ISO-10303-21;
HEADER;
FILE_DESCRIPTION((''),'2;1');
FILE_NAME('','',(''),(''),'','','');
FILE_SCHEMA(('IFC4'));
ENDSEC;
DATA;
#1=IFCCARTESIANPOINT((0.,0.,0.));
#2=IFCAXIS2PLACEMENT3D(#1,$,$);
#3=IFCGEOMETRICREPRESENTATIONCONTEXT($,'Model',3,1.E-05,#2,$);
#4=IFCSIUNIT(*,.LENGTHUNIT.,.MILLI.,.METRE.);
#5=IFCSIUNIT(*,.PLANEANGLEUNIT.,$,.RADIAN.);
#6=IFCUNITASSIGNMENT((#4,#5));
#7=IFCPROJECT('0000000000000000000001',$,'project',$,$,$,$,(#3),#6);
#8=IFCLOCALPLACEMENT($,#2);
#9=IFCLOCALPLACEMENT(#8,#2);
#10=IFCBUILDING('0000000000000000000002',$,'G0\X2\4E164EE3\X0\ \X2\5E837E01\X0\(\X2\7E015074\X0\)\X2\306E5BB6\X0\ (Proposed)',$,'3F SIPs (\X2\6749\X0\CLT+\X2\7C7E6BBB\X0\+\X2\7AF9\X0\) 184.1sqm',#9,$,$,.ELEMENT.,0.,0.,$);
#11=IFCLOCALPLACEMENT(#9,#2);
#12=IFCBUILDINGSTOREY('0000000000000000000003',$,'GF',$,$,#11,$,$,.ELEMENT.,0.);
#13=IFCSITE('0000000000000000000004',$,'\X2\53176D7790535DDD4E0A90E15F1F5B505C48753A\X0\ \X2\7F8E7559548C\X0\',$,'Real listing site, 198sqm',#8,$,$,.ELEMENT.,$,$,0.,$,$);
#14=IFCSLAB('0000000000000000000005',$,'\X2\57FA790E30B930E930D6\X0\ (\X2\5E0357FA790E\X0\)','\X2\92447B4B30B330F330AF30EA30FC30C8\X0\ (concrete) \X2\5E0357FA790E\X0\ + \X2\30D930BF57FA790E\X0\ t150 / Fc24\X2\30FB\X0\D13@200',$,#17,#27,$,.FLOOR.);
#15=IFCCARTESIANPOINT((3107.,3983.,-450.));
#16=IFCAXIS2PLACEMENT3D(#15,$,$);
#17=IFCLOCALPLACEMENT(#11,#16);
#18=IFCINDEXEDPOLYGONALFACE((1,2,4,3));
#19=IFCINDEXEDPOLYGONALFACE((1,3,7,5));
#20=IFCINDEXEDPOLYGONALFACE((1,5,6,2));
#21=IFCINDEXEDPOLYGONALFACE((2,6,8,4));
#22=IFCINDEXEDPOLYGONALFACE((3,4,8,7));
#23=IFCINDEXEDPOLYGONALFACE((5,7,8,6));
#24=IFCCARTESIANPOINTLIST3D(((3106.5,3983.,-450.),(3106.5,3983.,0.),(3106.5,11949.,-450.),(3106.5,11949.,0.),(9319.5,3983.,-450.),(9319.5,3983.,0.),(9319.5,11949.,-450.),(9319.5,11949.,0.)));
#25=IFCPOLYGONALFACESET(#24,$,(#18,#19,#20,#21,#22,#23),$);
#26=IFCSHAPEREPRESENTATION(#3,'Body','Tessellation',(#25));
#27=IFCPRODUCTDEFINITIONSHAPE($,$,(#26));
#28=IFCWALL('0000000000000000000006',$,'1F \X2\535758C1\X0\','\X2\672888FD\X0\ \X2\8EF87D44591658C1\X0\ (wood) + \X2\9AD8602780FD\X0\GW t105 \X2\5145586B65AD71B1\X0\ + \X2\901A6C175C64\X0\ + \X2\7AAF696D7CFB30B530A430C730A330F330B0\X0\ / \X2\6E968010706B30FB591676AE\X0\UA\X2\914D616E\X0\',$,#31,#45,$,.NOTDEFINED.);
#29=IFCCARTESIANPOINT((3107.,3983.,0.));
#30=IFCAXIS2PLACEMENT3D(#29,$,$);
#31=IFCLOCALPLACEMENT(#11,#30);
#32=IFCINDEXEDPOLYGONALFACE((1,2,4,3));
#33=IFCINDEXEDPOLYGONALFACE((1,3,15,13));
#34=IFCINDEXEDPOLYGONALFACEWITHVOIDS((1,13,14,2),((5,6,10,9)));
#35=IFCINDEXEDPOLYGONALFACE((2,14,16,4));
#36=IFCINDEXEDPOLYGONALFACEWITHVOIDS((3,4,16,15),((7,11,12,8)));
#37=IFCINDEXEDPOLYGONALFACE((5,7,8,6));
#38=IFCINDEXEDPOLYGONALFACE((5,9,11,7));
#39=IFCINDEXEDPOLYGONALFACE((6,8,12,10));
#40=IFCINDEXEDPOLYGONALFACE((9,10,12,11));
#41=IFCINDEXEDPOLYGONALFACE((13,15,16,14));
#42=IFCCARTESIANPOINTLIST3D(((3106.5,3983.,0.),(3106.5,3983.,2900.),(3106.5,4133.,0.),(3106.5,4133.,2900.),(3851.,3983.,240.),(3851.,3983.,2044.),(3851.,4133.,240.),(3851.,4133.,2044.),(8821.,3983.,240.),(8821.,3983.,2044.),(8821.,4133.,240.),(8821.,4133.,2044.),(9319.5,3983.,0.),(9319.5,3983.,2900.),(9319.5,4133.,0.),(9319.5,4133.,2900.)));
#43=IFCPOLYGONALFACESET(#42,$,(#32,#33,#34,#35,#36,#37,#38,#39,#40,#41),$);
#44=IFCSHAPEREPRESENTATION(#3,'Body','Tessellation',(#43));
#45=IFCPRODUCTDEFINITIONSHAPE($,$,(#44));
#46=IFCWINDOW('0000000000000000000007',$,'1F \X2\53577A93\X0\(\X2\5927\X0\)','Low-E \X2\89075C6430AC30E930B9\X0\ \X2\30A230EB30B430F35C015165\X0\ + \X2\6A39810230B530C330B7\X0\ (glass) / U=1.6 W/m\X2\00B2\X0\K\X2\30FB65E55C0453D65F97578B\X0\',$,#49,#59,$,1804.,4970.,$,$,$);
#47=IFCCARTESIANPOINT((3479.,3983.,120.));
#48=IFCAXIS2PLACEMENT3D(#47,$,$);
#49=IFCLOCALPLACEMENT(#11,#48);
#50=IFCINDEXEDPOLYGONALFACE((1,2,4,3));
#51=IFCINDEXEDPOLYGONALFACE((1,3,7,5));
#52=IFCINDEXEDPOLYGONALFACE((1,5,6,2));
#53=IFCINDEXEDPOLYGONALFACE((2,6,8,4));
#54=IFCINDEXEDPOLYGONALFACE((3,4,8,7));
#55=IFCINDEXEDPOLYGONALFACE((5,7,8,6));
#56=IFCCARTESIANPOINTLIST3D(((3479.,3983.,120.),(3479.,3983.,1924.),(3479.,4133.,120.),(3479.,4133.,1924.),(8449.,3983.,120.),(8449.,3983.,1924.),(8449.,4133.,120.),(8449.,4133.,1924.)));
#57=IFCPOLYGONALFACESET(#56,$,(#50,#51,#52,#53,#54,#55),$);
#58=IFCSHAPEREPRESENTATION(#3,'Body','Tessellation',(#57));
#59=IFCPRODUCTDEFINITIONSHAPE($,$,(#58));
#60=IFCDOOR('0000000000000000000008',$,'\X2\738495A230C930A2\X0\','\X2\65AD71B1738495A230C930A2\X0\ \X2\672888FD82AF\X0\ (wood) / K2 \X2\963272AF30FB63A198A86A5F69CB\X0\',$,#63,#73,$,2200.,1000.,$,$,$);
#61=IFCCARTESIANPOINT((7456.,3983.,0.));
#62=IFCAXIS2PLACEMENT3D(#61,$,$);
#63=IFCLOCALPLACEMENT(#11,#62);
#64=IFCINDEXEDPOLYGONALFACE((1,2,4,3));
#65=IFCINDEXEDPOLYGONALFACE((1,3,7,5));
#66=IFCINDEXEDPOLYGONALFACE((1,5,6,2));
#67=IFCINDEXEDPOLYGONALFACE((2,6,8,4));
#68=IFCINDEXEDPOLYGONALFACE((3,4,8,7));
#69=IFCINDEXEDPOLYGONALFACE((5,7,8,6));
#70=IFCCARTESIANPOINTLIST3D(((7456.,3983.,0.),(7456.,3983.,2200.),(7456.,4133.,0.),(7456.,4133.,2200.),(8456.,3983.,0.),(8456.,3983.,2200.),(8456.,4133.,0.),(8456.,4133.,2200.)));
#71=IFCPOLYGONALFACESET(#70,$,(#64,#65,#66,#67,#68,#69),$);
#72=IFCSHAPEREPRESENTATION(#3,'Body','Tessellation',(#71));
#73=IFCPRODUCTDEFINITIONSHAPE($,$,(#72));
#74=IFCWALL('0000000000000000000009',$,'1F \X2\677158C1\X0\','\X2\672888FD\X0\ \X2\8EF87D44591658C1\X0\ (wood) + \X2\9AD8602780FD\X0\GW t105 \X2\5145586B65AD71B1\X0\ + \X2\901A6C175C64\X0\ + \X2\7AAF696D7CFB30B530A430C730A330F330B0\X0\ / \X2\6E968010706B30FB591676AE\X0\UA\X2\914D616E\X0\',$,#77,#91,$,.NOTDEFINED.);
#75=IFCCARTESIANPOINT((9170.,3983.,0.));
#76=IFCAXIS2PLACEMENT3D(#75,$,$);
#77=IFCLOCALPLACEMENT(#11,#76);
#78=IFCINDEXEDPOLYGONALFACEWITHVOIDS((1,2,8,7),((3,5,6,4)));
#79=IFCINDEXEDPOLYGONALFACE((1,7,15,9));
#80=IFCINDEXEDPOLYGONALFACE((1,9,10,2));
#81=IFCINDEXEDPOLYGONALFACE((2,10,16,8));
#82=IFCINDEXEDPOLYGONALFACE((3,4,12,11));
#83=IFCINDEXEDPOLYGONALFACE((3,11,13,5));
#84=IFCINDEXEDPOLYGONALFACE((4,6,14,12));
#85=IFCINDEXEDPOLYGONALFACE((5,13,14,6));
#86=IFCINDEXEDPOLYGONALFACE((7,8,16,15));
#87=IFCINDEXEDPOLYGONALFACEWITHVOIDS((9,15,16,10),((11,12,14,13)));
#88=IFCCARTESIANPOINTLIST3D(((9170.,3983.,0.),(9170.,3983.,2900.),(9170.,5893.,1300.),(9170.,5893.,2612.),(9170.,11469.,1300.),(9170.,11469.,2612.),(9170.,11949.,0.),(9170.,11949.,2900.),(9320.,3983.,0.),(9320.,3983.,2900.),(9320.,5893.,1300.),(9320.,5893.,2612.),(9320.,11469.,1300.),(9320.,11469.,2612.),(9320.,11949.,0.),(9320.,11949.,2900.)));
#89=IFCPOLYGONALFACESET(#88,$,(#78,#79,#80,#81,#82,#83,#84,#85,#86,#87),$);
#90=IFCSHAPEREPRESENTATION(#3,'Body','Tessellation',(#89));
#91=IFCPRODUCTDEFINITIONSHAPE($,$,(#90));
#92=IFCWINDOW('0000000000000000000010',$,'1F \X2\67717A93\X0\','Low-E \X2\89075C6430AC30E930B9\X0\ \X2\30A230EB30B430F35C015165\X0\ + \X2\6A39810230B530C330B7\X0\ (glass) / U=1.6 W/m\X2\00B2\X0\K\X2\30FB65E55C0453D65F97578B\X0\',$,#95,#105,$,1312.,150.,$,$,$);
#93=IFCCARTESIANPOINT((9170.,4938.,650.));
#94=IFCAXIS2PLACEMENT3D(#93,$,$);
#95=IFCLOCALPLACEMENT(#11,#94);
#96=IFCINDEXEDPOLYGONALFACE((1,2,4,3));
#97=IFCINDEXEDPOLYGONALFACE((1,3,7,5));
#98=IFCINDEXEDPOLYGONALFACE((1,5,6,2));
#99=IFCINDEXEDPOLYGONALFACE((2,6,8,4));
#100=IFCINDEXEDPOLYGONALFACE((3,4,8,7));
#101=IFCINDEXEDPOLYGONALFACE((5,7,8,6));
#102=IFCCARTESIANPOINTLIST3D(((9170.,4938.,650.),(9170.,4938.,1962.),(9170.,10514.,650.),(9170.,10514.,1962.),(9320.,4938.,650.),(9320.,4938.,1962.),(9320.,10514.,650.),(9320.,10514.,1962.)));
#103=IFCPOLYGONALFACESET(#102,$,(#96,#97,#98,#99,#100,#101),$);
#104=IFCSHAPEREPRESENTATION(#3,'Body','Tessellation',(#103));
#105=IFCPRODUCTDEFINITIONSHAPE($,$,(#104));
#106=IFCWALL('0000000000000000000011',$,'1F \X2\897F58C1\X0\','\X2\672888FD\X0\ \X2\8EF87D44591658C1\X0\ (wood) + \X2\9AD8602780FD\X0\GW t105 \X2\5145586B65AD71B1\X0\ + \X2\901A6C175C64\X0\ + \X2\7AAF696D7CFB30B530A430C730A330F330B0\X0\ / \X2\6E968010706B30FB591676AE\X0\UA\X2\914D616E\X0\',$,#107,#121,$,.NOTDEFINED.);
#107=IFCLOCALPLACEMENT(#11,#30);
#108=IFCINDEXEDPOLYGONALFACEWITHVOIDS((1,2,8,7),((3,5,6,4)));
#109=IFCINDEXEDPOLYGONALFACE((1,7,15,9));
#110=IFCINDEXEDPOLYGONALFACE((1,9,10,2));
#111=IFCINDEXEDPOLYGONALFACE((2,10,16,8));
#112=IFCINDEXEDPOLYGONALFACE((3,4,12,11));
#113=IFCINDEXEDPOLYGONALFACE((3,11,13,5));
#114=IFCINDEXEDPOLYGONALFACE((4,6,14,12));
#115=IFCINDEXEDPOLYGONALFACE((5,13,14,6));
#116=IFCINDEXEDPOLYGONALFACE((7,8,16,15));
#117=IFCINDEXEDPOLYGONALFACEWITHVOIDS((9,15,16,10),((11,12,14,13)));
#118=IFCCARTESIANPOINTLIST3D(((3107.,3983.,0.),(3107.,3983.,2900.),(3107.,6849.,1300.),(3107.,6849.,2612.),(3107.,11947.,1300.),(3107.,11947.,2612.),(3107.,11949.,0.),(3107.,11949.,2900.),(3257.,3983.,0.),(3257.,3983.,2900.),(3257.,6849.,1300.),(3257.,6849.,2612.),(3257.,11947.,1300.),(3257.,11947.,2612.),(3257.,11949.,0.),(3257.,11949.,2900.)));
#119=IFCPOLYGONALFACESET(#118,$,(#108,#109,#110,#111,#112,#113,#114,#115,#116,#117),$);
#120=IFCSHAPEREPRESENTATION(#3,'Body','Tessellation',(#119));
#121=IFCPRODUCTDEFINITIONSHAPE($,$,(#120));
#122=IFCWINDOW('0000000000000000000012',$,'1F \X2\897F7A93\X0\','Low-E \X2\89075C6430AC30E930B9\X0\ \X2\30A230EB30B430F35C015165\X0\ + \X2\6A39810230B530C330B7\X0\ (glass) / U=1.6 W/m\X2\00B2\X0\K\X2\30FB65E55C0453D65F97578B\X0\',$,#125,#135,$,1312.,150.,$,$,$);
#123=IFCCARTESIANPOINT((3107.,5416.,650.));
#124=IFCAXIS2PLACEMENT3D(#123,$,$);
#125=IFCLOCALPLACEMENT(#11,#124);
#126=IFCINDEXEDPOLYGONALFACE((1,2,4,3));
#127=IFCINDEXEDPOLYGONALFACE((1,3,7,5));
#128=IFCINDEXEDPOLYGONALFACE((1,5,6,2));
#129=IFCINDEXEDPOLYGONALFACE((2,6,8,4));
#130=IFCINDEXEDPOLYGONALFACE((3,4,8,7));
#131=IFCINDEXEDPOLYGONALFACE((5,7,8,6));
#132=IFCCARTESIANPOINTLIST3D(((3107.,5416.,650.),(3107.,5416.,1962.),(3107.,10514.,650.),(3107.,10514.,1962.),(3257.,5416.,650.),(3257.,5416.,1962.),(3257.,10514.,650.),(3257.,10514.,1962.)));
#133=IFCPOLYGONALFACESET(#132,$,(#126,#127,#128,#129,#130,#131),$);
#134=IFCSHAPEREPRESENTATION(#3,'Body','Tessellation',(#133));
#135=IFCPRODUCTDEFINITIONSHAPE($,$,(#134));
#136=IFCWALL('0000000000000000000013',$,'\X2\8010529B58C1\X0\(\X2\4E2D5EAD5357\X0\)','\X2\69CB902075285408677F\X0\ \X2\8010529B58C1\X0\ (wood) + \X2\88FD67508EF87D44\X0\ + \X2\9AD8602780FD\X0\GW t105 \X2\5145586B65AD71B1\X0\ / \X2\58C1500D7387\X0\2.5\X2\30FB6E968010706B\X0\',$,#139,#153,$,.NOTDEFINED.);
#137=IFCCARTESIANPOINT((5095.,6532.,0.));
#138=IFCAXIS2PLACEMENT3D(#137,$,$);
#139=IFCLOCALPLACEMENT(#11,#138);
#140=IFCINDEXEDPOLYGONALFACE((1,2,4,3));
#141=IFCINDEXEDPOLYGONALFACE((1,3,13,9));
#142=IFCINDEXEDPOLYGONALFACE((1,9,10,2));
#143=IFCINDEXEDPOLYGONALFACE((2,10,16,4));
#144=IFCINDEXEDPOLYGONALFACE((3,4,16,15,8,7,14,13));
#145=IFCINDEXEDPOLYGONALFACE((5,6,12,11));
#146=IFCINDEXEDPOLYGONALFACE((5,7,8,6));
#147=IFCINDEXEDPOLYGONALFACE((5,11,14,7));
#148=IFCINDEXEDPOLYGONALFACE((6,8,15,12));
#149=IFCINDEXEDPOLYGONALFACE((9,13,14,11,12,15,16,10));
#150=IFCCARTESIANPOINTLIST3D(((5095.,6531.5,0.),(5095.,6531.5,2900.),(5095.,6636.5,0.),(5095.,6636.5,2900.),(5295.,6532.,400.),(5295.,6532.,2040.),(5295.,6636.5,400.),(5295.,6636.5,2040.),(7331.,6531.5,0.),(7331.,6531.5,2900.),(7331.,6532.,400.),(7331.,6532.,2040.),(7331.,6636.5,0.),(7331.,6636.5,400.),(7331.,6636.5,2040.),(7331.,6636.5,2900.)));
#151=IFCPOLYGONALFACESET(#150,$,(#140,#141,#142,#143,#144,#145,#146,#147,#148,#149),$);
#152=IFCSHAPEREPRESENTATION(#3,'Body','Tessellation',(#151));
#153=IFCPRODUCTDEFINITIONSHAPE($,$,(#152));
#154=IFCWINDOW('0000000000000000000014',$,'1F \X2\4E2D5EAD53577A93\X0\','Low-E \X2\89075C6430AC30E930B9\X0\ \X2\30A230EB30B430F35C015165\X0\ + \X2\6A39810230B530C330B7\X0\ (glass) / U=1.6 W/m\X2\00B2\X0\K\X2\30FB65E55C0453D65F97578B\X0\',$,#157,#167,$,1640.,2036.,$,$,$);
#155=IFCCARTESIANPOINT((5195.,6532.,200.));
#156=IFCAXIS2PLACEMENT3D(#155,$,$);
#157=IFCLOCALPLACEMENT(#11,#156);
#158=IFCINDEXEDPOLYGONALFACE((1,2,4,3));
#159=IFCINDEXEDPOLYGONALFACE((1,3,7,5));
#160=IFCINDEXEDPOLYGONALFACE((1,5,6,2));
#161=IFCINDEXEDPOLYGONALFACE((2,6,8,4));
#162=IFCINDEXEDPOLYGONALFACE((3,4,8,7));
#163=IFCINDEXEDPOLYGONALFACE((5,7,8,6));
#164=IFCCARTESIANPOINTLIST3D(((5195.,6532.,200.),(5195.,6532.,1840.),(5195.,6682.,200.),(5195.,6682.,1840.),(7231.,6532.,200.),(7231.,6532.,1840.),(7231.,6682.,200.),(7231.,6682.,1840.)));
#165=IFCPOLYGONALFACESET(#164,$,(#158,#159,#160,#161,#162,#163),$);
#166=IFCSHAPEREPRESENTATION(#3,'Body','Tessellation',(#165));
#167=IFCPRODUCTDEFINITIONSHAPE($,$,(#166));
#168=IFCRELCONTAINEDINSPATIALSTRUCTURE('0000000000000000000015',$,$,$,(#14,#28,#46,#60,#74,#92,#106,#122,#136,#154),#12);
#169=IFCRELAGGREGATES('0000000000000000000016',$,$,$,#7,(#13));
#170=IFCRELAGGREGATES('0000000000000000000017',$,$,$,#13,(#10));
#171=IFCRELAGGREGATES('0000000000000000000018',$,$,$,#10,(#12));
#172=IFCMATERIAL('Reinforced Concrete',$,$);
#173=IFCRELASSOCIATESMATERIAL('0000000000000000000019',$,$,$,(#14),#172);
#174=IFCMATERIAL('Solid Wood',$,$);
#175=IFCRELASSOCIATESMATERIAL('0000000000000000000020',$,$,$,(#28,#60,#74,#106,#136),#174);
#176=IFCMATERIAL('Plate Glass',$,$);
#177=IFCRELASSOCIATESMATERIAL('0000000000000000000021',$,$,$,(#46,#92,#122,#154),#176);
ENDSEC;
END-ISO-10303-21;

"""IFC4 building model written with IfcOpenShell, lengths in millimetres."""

from ifc_helpers import new_model, si_unit, frame, frame_2d, origin, place, context, project, spatial, rectangle, extrude, material, element, fill, save


model = new_model("IFC4")

# Units and contexts
model_context = context("Model", 3, precision=1e-05, world=origin())
ifc_project = project(units=[si_unit("LENGTHUNIT", "METRE", prefix="MILLI"), si_unit("PLANEANGLEUNIT", "RADIAN")], contexts=[model_context])

# Site, building, storey
site_placement = place(None, origin())
site = spatial("IfcSite", under=ifc_project, at=site_placement, Name="北海道川上郡弟子屈町 美留和", ObjectType="Real listing site, 198sqm", CompositionType="ELEMENT", RefElevation=0.0)
building_placement = place(site_placement, origin())
building = spatial("IfcBuilding", under=site, at=building_placement, Name="G0世代 広縁(縁側)の家 (Proposed)", ObjectType="3F SIPs (杉CLT+籾殻+竹) 184.1sqm", CompositionType="ELEMENT", ElevationOfRefHeight=0.0, ElevationOfTerrain=0.0)
storey_placement = place(building_placement, origin())
storey = spatial("IfcBuildingStorey", under=building, at=storey_placement, Name="GF", CompositionType="ELEMENT", Elevation=0.0)

# Slab
ifc_material_1 = material(Name="Reinforced Concrete")
slab_1_placement = place(storey_placement, frame((3107.0, 3983.0, -450.0)))
element("IfcSlab", 1, at=slab_1_placement, inside=storey, material=ifc_material_1, Name="基礎スラブ (布基礎)", Description="鉄筋コンクリート (concrete) 布基礎 + ベタ基礎 t150 / Fc24・D13@200", PredefinedType="FLOOR", context=model_context, shape_type="SweptSolid", body=[
    extrude(rectangle(XDim=6213.0, YDim=7966.0, at=frame_2d((3106.0, 3983.0))), frame((3107.0, 3983.0, -450.0)), (0.0, 0.0, 1.0), 450.0),
])
ifc_material_2 = material(Name="Solid Wood")

# Wall, openings, window, door
wall_1_placement = place(storey_placement, frame((3107.0, 3983.0, 0.0)))
wall_1 = element("IfcWall", 2, at=wall_1_placement, inside=storey, material=ifc_material_2, Name="1F 南壁", Description="木製 軸組外壁 (wood) + 高性能GW t105 充填断熱 + 通気層 + 窯業系サイディング / 準耐火・外皮UA配慮", PredefinedType="NOTDEFINED", context=model_context, shape_type="SweptSolid", body=[
    extrude(rectangle(XDim=6213.0, YDim=150.0, at=frame_2d((3106.0, 75.0))), frame((3107.0, 3983.0, 0.0)), (0.0, 0.0, 1.0), 2900.0),
])
opening_1_placement = place(storey_placement, frame((3479.0, 3983.0, 120.0)))
opening_1 = element("IfcOpeningElement", 3, at=opening_1_placement, cuts=wall_1, PredefinedType="NOTDEFINED", context=model_context, shape_type="SweptSolid", body=[
    extrude(rectangle(XDim=4970.0, YDim=150.0, at=frame_2d((2485.0, 75.0))), frame((3479.0, 3983.0, 120.0)), (0.0, 0.0, 1.0), 1804.0),
])
opening_2_placement = place(storey_placement, frame((7456.0, 3983.0, 0.0)))
opening_2 = element("IfcOpeningElement", 4, at=opening_2_placement, cuts=wall_1, PredefinedType="NOTDEFINED", context=model_context, shape_type="SweptSolid", body=[
    extrude(rectangle(XDim=1000.0, YDim=150.0, at=frame_2d((500.0, 75.0))), frame((7456.0, 3983.0, 0.0)), (0.0, 0.0, 1.0), 2200.0),
])
ifc_material_3 = material(Name="Plate Glass")
window_1_placement = place(storey_placement, frame((3479.0, 3983.0, 120.0)))
window_1 = element("IfcWindow", 5, at=window_1_placement, inside=storey, material=ifc_material_3, Name="1F 南窓(大)", Description="Low-E 複層ガラス アルゴン封入 + 樹脂サッシ (glass) / U=1.6 W/m²K・日射取得型", OverallHeight=1804.0, OverallWidth=4970.0, context=model_context, shape_type="SweptSolid", body=[
    extrude(rectangle(XDim=4970.0, YDim=150.0, at=frame_2d((2485.0, 75.0))), frame((3479.0, 3983.0, 120.0)), (0.0, 0.0, 1.0), 1804.0),
])
fill(opening_1, window_1)
door_placement = place(storey_placement, frame((7456.0, 3983.0, 0.0)))
door = element("IfcDoor", 6, at=door_placement, inside=storey, material=ifc_material_2, Name="玄関ドア", Description="断熱玄関ドア 木製芯 (wood) / K2 防犯・採風機構", OverallHeight=2200.0, OverallWidth=1000.0, context=model_context, shape_type="SweptSolid", body=[
    extrude(rectangle(XDim=1000.0, YDim=150.0, at=frame_2d((500.0, 75.0))), frame((7456.0, 3983.0, 0.0)), (0.0, 0.0, 1.0), 2200.0),
])
fill(opening_2, door)

# Walls, openings, windows
wall_2_placement = place(storey_placement, frame((9170.0, 3983.0, 0.0)))
wall_2 = element("IfcWall", 7, at=wall_2_placement, inside=storey, material=ifc_material_2, Name="1F 東壁", Description="木製 軸組外壁 (wood) + 高性能GW t105 充填断熱 + 通気層 + 窯業系サイディング / 準耐火・外皮UA配慮", PredefinedType="NOTDEFINED", context=model_context, shape_type="SweptSolid", body=[
    extrude(rectangle(XDim=150.0, YDim=7966.0, at=frame_2d((75.0, 3983.0))), frame((9170.0, 3983.0, 0.0)), (0.0, 0.0, 1.0), 2900.0),
])
opening_3_placement = place(storey_placement, frame((9170.0, 4938.0, 650.0)))
opening_3 = element("IfcOpeningElement", 8, at=opening_3_placement, cuts=wall_2, PredefinedType="NOTDEFINED", context=model_context, shape_type="SweptSolid", body=[
    extrude(rectangle(XDim=150.0, YDim=5576.0, at=frame_2d((75.0, 2788.0))), frame((9170.0, 4938.0, 650.0)), (0.0, 0.0, 1.0), 1312.0),
])
window_2_placement = place(storey_placement, frame((9170.0, 4938.0, 650.0)))
window_2 = element("IfcWindow", 9, at=window_2_placement, inside=storey, material=ifc_material_3, Name="1F 東窓", Description="Low-E 複層ガラス アルゴン封入 + 樹脂サッシ (glass) / U=1.6 W/m²K・日射取得型", OverallHeight=1312.0, OverallWidth=150.0, context=model_context, shape_type="SweptSolid", body=[
    extrude(rectangle(XDim=150.0, YDim=5576.0, at=frame_2d((75.0, 2788.0))), frame((9170.0, 4938.0, 650.0)), (0.0, 0.0, 1.0), 1312.0),
])
fill(opening_3, window_2)
wall_3_placement = place(storey_placement, frame((3107.0, 3983.0, 0.0)))
wall_3 = element("IfcWall", 10, at=wall_3_placement, inside=storey, material=ifc_material_2, Name="1F 西壁", Description="木製 軸組外壁 (wood) + 高性能GW t105 充填断熱 + 通気層 + 窯業系サイディング / 準耐火・外皮UA配慮", PredefinedType="NOTDEFINED", context=model_context, shape_type="SweptSolid", body=[
    extrude(rectangle(XDim=150.0, YDim=7966.0, at=frame_2d((75.0, 3983.0))), frame((3107.0, 3983.0, 0.0)), (0.0, 0.0, 1.0), 2900.0),
])
opening_4_placement = place(storey_placement, frame((3107.0, 5416.0, 650.0)))
opening_4 = element("IfcOpeningElement", 11, at=opening_4_placement, cuts=wall_3, PredefinedType="NOTDEFINED", context=model_context, shape_type="SweptSolid", body=[
    extrude(rectangle(XDim=150.0, YDim=5098.0, at=frame_2d((75.0, 2549.0))), frame((3107.0, 5416.0, 650.0)), (0.0, 0.0, 1.0), 1312.0),
])
window_3_placement = place(storey_placement, frame((3107.0, 5416.0, 650.0)))
window_3 = element("IfcWindow", 12, at=window_3_placement, inside=storey, material=ifc_material_3, Name="1F 西窓", Description="Low-E 複層ガラス アルゴン封入 + 樹脂サッシ (glass) / U=1.6 W/m²K・日射取得型", OverallHeight=1312.0, OverallWidth=150.0, context=model_context, shape_type="SweptSolid", body=[
    extrude(rectangle(XDim=150.0, YDim=5098.0, at=frame_2d((75.0, 2549.0))), frame((3107.0, 5416.0, 650.0)), (0.0, 0.0, 1.0), 1312.0),
])
fill(opening_4, window_3)
wall_4_placement = place(storey_placement, frame((5095.0, 6532.0, 0.0)))
wall_4 = element("IfcWall", 13, at=wall_4_placement, inside=storey, material=ifc_material_2, Name="耐力壁(中庭南)", Description="構造用合板 耐力壁 (wood) + 製材軸組 + 高性能GW t105 充填断熱 / 壁倍率2.5・準耐火", PredefinedType="NOTDEFINED", context=model_context, shape_type="SweptSolid", body=[
    extrude(rectangle(XDim=2236.0, YDim=105.0, at=frame_2d((1118.0, 52.0))), frame((5095.0, 6532.0, 0.0)), (0.0, 0.0, 1.0), 2900.0),
])
opening_5_placement = place(storey_placement, frame((5195.0, 6532.0, 200.0)))
opening_5 = element("IfcOpeningElement", 14, at=opening_5_placement, cuts=wall_4, PredefinedType="NOTDEFINED", context=model_context, shape_type="SweptSolid", body=[
    extrude(rectangle(XDim=2036.0, YDim=150.0, at=frame_2d((1018.0, 75.0))), frame((5195.0, 6532.0, 200.0)), (0.0, 0.0, 1.0), 1640.0),
])
window_4_placement = place(storey_placement, frame((5195.0, 6532.0, 200.0)))
window_4 = element("IfcWindow", 15, at=window_4_placement, inside=storey, material=ifc_material_3, Name="1F 中庭南窓", Description="Low-E 複層ガラス アルゴン封入 + 樹脂サッシ (glass) / U=1.6 W/m²K・日射取得型", OverallHeight=1640.0, OverallWidth=2036.0, context=model_context, shape_type="SweptSolid", body=[
    extrude(rectangle(XDim=2036.0, YDim=150.0, at=frame_2d((1018.0, 75.0))), frame((5195.0, 6532.0, 200.0)), (0.0, 0.0, 1.0), 1640.0),
])
fill(opening_5, window_4)

save(model, "model.ifc")
